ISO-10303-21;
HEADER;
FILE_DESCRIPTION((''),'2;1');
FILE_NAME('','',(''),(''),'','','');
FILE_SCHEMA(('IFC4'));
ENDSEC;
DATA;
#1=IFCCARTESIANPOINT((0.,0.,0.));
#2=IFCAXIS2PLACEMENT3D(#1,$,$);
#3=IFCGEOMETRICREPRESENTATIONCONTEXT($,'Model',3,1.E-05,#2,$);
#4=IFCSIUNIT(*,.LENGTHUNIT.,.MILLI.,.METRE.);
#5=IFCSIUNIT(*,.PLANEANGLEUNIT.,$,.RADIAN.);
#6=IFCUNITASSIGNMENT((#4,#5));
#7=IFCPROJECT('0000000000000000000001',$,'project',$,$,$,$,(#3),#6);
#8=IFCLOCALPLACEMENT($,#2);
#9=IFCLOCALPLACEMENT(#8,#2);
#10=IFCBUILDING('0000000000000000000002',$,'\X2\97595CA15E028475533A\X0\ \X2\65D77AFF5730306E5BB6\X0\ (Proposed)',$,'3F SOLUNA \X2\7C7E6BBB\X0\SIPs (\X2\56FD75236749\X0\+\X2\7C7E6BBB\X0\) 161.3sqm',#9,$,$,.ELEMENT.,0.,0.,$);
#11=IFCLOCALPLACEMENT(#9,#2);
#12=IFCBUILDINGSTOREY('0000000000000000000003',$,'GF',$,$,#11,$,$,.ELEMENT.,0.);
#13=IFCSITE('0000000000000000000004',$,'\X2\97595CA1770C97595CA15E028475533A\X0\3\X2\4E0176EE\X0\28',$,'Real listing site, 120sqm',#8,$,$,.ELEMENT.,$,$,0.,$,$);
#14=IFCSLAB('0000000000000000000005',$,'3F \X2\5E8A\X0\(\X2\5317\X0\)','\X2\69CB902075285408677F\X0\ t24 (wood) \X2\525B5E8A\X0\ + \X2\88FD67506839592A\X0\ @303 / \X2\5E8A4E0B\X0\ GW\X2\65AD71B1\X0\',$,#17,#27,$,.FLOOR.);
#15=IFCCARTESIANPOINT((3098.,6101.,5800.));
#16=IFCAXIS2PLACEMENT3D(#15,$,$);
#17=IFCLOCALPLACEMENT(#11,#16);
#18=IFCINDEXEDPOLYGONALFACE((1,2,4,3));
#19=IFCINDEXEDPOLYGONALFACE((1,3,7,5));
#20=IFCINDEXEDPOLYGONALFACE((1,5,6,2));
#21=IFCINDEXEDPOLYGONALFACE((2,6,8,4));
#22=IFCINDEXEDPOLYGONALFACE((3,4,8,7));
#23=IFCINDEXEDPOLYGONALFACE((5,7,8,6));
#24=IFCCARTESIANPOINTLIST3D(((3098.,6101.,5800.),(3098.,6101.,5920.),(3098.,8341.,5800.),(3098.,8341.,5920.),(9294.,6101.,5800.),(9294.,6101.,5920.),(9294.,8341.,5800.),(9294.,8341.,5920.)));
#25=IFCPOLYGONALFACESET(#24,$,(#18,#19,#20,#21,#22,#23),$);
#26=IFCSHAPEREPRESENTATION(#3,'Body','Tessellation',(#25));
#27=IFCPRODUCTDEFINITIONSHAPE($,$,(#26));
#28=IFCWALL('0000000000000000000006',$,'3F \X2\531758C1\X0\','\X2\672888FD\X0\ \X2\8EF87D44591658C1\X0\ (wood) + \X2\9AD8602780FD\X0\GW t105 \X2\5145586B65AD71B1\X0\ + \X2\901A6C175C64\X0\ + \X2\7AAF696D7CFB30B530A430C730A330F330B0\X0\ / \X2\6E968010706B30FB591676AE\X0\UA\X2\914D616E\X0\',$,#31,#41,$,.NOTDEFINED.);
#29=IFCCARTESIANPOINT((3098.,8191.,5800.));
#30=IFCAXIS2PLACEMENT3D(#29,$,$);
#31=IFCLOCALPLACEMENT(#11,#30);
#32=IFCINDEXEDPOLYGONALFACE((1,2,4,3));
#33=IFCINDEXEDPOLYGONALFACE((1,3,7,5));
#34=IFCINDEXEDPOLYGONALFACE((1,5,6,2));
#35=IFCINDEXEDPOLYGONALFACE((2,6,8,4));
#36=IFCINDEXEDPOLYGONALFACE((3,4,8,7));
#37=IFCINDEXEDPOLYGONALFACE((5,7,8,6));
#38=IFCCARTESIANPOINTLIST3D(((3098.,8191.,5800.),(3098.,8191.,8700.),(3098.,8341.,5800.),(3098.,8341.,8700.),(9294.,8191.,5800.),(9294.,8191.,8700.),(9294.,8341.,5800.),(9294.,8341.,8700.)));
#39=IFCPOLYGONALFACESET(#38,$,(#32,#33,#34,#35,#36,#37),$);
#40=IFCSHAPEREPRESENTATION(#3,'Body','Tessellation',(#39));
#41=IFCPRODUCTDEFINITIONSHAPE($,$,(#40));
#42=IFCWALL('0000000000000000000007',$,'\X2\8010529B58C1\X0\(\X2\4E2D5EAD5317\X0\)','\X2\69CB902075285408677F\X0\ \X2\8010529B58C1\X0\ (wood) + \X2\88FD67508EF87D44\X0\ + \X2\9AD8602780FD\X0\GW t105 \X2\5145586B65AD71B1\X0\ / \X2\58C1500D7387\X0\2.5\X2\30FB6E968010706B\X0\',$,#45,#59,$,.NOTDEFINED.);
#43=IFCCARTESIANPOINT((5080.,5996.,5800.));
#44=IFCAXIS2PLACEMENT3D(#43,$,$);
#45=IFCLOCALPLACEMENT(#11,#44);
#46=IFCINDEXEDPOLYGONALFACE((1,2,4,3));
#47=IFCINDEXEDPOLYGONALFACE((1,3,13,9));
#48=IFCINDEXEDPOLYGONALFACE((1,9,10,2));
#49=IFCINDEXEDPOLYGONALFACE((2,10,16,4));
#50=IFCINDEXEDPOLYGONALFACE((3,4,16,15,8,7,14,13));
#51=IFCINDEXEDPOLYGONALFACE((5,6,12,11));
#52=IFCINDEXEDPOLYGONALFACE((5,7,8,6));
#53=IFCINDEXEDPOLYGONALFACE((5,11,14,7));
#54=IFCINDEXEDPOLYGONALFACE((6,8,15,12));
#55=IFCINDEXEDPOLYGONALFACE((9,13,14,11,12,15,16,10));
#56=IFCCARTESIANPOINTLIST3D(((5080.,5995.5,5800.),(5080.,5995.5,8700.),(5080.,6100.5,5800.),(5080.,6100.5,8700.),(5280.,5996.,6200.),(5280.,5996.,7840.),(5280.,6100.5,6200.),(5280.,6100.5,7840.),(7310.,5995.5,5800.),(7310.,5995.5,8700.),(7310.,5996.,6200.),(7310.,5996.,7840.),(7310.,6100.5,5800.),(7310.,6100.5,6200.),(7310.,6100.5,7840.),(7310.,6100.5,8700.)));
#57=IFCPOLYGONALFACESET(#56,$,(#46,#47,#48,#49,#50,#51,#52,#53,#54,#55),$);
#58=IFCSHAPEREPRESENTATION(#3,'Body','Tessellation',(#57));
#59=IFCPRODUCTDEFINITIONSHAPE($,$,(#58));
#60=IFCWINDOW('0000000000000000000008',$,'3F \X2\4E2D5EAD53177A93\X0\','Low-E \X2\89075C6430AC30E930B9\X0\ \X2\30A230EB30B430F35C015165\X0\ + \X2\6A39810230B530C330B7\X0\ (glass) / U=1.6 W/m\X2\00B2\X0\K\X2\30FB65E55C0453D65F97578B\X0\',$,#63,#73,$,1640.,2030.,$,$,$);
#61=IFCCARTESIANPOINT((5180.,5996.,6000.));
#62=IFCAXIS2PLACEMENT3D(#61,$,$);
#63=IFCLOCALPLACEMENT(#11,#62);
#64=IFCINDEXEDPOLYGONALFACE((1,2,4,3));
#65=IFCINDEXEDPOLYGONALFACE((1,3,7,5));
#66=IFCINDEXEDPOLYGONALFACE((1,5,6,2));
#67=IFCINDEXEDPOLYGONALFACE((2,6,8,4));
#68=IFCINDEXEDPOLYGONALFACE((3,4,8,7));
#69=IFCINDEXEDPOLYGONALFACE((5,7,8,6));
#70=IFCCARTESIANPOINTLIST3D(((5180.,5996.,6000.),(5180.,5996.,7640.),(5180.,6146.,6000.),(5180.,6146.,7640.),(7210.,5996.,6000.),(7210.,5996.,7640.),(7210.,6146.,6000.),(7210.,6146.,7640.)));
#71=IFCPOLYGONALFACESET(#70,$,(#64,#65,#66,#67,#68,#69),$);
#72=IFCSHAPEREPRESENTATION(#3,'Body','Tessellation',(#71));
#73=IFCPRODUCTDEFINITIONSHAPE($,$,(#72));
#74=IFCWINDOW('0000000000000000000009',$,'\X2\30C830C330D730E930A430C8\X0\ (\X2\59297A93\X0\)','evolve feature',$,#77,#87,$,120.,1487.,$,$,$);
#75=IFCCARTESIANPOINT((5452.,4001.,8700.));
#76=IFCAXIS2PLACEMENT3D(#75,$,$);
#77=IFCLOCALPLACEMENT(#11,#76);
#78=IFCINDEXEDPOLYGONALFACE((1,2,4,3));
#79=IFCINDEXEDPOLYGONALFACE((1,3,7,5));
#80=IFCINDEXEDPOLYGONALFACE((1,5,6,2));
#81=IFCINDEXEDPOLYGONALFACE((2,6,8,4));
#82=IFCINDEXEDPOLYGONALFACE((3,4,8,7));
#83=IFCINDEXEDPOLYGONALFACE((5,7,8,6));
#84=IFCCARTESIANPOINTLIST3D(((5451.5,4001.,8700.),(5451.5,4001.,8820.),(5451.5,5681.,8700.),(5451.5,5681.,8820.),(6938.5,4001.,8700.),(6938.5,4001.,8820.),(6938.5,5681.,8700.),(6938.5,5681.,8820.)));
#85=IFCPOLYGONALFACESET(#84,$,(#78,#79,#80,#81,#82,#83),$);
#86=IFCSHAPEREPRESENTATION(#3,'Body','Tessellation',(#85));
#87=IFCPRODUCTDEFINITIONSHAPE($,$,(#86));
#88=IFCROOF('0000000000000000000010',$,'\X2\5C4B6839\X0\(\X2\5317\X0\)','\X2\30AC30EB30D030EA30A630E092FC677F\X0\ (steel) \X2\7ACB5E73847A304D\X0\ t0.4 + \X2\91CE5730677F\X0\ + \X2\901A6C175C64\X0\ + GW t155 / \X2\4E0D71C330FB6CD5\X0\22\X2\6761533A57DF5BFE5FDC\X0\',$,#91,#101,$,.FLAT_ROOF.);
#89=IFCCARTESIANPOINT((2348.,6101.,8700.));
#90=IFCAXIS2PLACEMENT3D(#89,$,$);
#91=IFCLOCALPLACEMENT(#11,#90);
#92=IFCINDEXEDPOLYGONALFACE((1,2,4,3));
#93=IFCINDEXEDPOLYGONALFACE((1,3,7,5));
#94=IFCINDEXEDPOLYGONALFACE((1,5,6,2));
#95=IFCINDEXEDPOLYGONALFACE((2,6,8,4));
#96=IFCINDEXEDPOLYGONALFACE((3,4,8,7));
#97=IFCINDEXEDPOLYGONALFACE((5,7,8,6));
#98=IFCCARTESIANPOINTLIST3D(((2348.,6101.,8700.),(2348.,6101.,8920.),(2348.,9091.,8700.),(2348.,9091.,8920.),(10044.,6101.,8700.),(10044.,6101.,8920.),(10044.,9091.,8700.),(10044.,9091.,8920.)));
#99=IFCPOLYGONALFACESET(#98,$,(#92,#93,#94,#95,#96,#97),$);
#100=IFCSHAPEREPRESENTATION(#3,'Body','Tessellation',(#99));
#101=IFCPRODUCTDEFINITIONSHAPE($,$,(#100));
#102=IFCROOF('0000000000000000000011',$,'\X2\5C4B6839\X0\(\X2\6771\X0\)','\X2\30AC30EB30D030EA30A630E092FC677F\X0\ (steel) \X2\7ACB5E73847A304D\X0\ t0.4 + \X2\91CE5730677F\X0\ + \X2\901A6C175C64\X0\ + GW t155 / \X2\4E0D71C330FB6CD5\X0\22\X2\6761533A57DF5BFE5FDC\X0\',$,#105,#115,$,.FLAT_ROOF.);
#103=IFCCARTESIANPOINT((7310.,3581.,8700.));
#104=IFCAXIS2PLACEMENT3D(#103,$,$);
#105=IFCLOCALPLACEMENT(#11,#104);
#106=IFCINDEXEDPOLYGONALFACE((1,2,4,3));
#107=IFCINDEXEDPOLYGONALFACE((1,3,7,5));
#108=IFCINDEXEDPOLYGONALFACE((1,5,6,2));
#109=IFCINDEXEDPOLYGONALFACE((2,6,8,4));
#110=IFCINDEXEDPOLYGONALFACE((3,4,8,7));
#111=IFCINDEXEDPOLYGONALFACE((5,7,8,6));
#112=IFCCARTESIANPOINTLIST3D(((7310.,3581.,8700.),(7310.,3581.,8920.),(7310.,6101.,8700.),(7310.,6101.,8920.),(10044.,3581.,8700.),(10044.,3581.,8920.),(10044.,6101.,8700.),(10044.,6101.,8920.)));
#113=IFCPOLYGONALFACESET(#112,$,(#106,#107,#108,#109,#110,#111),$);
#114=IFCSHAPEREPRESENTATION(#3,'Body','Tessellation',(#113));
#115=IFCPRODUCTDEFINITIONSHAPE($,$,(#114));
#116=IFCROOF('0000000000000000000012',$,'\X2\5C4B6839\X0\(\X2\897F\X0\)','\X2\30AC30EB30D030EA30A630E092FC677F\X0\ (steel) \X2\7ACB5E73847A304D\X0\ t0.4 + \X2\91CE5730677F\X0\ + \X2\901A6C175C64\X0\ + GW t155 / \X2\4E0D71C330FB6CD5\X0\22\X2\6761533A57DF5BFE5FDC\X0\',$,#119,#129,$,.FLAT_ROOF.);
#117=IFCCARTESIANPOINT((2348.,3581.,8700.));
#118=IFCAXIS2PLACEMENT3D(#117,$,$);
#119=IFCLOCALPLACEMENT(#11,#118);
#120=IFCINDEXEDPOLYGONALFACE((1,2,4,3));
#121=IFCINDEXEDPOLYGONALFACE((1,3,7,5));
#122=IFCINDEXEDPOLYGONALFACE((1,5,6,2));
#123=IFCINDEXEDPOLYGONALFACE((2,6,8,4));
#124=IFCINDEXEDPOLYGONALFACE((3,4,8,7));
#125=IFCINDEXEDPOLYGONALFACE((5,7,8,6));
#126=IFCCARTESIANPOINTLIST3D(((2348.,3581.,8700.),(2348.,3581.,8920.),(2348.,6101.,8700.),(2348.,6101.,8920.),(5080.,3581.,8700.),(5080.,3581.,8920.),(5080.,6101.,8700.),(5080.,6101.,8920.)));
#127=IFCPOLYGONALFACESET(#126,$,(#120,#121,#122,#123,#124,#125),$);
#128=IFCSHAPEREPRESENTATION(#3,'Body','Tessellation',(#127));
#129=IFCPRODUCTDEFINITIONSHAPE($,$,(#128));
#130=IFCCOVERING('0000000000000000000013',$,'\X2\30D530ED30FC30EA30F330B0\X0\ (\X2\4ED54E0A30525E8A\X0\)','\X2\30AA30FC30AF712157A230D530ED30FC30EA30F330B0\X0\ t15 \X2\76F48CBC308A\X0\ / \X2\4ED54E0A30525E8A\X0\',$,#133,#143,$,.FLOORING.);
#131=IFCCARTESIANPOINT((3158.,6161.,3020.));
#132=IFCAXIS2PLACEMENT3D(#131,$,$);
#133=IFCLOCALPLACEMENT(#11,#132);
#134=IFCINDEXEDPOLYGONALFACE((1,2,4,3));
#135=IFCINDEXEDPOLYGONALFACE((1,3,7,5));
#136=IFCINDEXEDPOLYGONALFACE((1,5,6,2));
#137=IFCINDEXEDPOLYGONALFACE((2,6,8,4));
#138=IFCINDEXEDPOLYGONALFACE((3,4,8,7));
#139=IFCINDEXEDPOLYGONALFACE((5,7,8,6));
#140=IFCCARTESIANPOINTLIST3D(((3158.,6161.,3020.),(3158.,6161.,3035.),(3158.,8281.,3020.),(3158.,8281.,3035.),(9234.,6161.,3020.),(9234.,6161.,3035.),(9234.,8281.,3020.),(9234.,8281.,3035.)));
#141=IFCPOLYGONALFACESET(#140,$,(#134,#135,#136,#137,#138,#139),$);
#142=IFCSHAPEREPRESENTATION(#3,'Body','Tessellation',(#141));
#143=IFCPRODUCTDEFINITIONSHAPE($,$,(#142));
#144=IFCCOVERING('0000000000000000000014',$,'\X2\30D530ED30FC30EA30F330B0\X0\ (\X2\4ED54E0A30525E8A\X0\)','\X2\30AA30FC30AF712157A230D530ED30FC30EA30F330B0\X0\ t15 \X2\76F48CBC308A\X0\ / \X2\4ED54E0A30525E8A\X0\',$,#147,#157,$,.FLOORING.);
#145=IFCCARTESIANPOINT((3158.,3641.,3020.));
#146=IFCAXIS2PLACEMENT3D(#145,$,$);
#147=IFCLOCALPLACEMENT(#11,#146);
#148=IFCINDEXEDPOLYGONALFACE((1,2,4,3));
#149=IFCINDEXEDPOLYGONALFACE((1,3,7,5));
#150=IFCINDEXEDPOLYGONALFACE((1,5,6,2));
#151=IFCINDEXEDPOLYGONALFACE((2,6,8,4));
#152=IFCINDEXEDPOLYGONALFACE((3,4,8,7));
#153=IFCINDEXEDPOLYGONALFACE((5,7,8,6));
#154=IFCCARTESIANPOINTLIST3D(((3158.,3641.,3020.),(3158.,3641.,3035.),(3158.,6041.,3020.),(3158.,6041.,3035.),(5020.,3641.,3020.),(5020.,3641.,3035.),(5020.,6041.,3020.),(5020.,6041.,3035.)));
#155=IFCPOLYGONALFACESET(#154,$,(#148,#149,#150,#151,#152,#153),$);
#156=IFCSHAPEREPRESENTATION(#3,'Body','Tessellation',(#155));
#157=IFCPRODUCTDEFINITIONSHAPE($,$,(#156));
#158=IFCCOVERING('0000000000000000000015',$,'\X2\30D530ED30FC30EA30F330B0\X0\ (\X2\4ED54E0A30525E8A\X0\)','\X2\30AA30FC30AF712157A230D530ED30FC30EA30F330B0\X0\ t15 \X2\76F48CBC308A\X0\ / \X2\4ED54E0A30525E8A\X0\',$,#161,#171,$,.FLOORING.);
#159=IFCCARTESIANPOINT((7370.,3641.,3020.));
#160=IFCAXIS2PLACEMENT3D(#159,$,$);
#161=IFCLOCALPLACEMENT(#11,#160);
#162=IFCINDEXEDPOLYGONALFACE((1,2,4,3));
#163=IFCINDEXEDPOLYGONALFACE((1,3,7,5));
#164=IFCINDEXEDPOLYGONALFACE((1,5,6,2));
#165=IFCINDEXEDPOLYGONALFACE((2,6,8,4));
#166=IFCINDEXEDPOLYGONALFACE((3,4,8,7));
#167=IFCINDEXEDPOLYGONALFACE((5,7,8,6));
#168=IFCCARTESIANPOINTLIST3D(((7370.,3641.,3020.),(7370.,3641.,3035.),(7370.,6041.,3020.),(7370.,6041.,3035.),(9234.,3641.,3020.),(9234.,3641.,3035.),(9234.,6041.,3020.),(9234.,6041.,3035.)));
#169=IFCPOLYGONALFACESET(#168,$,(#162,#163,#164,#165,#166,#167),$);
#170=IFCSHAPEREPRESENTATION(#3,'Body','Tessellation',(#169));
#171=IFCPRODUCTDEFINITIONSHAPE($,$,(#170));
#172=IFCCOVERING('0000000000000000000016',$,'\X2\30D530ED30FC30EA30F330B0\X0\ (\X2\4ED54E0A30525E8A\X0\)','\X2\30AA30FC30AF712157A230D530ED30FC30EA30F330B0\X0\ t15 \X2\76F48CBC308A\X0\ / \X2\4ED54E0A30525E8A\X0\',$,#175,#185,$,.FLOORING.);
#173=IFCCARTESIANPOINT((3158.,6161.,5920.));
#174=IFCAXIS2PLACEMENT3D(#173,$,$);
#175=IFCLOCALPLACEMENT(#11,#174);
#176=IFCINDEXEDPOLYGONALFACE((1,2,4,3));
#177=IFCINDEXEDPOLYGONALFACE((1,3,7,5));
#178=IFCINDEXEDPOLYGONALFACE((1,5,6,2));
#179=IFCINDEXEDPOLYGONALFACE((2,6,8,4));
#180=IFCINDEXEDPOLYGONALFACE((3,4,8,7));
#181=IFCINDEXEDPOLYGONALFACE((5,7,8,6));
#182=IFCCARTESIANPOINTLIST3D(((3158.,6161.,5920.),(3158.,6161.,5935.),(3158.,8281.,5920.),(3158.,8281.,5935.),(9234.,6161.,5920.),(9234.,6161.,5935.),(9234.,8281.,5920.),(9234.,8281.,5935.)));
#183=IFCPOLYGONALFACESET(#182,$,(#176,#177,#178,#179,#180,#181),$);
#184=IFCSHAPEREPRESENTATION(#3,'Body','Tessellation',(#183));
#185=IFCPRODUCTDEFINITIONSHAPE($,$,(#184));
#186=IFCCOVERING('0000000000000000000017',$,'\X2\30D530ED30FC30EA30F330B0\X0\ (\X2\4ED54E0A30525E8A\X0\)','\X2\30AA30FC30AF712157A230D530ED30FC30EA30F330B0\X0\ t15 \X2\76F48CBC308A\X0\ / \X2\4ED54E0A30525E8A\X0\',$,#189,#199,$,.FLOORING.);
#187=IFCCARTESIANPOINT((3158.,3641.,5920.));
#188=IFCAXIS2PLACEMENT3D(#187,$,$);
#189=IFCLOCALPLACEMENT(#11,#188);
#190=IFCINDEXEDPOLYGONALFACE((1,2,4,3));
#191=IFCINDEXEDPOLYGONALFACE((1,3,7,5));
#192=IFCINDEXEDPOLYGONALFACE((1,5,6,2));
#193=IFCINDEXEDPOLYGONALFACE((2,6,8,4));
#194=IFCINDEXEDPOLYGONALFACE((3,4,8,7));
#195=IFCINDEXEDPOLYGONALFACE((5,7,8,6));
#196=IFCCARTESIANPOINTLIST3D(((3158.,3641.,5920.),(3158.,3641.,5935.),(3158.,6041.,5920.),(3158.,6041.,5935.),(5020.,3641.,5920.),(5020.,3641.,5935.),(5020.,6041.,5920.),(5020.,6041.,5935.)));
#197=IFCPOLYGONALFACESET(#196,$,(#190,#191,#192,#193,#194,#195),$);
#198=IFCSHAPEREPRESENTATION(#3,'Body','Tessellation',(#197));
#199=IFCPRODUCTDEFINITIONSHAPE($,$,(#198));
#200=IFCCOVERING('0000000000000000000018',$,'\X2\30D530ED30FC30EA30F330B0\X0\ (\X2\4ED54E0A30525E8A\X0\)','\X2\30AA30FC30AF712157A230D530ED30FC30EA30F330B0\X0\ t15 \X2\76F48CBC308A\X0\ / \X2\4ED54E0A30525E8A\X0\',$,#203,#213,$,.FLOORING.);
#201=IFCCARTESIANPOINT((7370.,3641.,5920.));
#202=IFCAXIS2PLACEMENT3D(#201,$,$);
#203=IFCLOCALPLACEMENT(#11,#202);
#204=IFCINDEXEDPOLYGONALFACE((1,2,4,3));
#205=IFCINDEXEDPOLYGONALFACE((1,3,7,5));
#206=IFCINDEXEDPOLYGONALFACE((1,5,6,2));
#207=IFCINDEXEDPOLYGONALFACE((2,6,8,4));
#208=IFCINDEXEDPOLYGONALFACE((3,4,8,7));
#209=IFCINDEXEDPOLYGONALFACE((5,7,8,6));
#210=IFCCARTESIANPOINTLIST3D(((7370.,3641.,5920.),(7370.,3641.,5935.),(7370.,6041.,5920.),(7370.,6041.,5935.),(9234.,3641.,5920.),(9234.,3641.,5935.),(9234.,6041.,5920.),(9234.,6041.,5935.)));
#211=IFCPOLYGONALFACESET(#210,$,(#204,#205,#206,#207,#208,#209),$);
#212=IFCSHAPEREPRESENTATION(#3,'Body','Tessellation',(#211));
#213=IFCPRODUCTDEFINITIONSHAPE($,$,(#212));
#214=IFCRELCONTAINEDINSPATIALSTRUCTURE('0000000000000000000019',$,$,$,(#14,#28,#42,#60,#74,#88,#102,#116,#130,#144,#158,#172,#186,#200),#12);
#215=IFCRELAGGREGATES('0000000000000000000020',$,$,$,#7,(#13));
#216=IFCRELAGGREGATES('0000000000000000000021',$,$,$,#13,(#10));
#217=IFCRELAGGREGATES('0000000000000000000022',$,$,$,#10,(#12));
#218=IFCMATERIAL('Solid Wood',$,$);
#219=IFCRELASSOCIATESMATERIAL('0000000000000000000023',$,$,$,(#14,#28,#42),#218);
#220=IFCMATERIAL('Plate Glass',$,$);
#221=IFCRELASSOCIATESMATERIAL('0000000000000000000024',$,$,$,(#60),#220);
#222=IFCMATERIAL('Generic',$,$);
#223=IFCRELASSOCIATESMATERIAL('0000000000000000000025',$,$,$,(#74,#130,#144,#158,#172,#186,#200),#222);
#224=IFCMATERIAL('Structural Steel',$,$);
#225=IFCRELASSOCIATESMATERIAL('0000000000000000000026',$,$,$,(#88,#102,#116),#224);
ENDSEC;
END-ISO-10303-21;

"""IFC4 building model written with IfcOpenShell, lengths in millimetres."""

from ifc_helpers import new_model, si_unit, frame, frame_2d, origin, place, context, project, spatial, rectangle, extrude, material, element, fill, save


model = new_model("IFC4")

# Units and contexts
model_context = context("Model", 3, precision=1e-05, world=origin())
ifc_project = project(units=[si_unit("LENGTHUNIT", "METRE", prefix="MILLI"), si_unit("PLANEANGLEUNIT", "RADIAN")], contexts=[model_context])

# Site, building, storey
site_placement = place(None, origin())
site = spatial("IfcSite", under=ifc_project, at=site_placement, Name="静岡県静岡市葵区3丁目28", ObjectType="Real listing site, 120sqm", CompositionType="ELEMENT", RefElevation=0.0)
building_placement = place(site_placement, origin())
building = spatial("IfcBuilding", under=site, at=building_placement, Name="静岡市葵区 旗竿地の家 (Proposed)", ObjectType="3F SOLUNA 籾殻SIPs (国産杉+籾殻) 161.3sqm", CompositionType="ELEMENT", ElevationOfRefHeight=0.0, ElevationOfTerrain=0.0)
storey_placement = place(building_placement, origin())
storey = spatial("IfcBuildingStorey", under=building, at=storey_placement, Name="GF", CompositionType="ELEMENT", Elevation=0.0)

# Slab
ifc_material_1 = material(Name="Solid Wood")
slab_placement = place(storey_placement, frame((3098.0, 6101.0, 5800.0)))
element("IfcSlab", 1, at=slab_placement, inside=storey, material=ifc_material_1, Name="3F 床(北)", Description="構造用合板 t24 (wood) 剛床 + 製材根太 @303 / 床下 GW断熱", PredefinedType="FLOOR", context=model_context, shape_type="SweptSolid", body=[
    extrude(rectangle(XDim=6196.0, YDim=2240.0, at=frame_2d((3098.0, 1120.0))), frame((3098.0, 6101.0, 5800.0)), (0.0, 0.0, 1.0), 120.0),
])

# Wall
wall_1_placement = place(storey_placement, frame((3098.0, 8191.0, 5800.0)))
element("IfcWall", 2, at=wall_1_placement, inside=storey, material=ifc_material_1, Name="3F 北壁", Description="木製 軸組外壁 (wood) + 高性能GW t105 充填断熱 + 通気層 + 窯業系サイディング / 準耐火・外皮UA配慮", PredefinedType="NOTDEFINED", context=model_context, shape_type="SweptSolid", body=[
    extrude(rectangle(XDim=6196.0, YDim=150.0, at=frame_2d((3098.0, 75.0))), frame((3098.0, 8191.0, 5800.0)), (0.0, 0.0, 1.0), 2900.0),
])

# Wall, opening, window
wall_2_placement = place(storey_placement, frame((5080.0, 5996.0, 5800.0)))
wall_2 = element("IfcWall", 3, at=wall_2_placement, inside=storey, material=ifc_material_1, Name="耐力壁(中庭北)", Description="構造用合板 耐力壁 (wood) + 製材軸組 + 高性能GW t105 充填断熱 / 壁倍率2.5・準耐火", PredefinedType="NOTDEFINED", context=model_context, shape_type="SweptSolid", body=[
    extrude(rectangle(XDim=2230.0, YDim=105.0, at=frame_2d((1115.0, 52.0))), frame((5080.0, 5996.0, 5800.0)), (0.0, 0.0, 1.0), 2900.0),
])
opening_placement = place(storey_placement, frame((5180.0, 5996.0, 6000.0)))
opening = element("IfcOpeningElement", 4, at=opening_placement, cuts=wall_2, PredefinedType="NOTDEFINED", context=model_context, shape_type="SweptSolid", body=[
    extrude(rectangle(XDim=2030.0, YDim=150.0, at=frame_2d((1015.0, 75.0))), frame((5180.0, 5996.0, 6000.0)), (0.0, 0.0, 1.0), 1640.0),
])
ifc_material_2 = material(Name="Plate Glass")
window_1_placement = place(storey_placement, frame((5180.0, 5996.0, 6000.0)))
window_1 = element("IfcWindow", 5, at=window_1_placement, inside=storey, material=ifc_material_2, Name="3F 中庭北窓", Description="Low-E 複層ガラス アルゴン封入 + 樹脂サッシ (glass) / U=1.6 W/m²K・日射取得型", OverallHeight=1640.0, OverallWidth=2030.0, context=model_context, shape_type="SweptSolid", body=[
    extrude(rectangle(XDim=2030.0, YDim=150.0, at=frame_2d((1015.0, 75.0))), frame((5180.0, 5996.0, 6000.0)), (0.0, 0.0, 1.0), 1640.0),
])
fill(opening, window_1)

# Window
ifc_material_3 = material(Name="Generic")
window_2_placement = place(storey_placement, frame((5452.0, 4001.0, 8700.0)))
element("IfcWindow", 6, at=window_2_placement, inside=storey, material=ifc_material_3, Name="トップライト (天窓)", Description="evolve feature", OverallHeight=120.0, OverallWidth=1487.0, context=model_context, shape_type="SweptSolid", body=[
    extrude(rectangle(XDim=1487.0, YDim=1680.0, at=frame_2d((743.0, 840.0))), frame((5452.0, 4001.0, 8700.0)), (0.0, 0.0, 1.0), 120.0),
])

# Roofs
ifc_material_4 = material(Name="Structural Steel")
roof_1_placement = place(storey_placement, frame((2348.0, 6101.0, 8700.0)))
element("IfcRoof", 7, at=roof_1_placement, inside=storey, material=ifc_material_4, Name="屋根(北)", Description="ガルバリウム鋼板 (steel) 立平葺き t0.4 + 野地板 + 通気層 + GW t155 / 不燃・法22条区域対応", PredefinedType="FLAT_ROOF", context=model_context, shape_type="SweptSolid", body=[
    extrude(rectangle(XDim=7696.0, YDim=2990.0, at=frame_2d((3848.0, 1495.0))), frame((2348.0, 6101.0, 8700.0)), (0.0, 0.0, 1.0), 220.0),
])
roof_2_placement = place(storey_placement, frame((7310.0, 3581.0, 8700.0)))
element("IfcRoof", 8, at=roof_2_placement, inside=storey, material=ifc_material_4, Name="屋根(東)", Description="ガルバリウム鋼板 (steel) 立平葺き t0.4 + 野地板 + 通気層 + GW t155 / 不燃・法22条区域対応", PredefinedType="FLAT_ROOF", context=model_context, shape_type="SweptSolid", body=[
    extrude(rectangle(XDim=2734.0, YDim=2520.0, at=frame_2d((1367.0, 1260.0))), frame((7310.0, 3581.0, 8700.0)), (0.0, 0.0, 1.0), 220.0),
])
roof_3_placement = place(storey_placement, frame((2348.0, 3581.0, 8700.0)))
element("IfcRoof", 9, at=roof_3_placement, inside=storey, material=ifc_material_4, Name="屋根(西)", Description="ガルバリウム鋼板 (steel) 立平葺き t0.4 + 野地板 + 通気層 + GW t155 / 不燃・法22条区域対応", PredefinedType="FLAT_ROOF", context=model_context, shape_type="SweptSolid", body=[
    extrude(rectangle(XDim=2732.0, YDim=2520.0, at=frame_2d((1366.0, 1260.0))), frame((2348.0, 3581.0, 8700.0)), (0.0, 0.0, 1.0), 220.0),
])

# Coverings
covering_1_placement = place(storey_placement, frame((3158.0, 6161.0, 3020.0)))
element("IfcCovering", 10, at=covering_1_placement, inside=storey, material=ifc_material_3, Name="フローリング (仕上げ床)", Description="オーク無垢フローリング t15 直貼り / 仕上げ床", PredefinedType="FLOORING", context=model_context, shape_type="SweptSolid", body=[
    extrude(rectangle(XDim=6076.0, YDim=2120.0, at=frame_2d((3038.0, 1060.0))), frame((3158.0, 6161.0, 3020.0)), (0.0, 0.0, 1.0), 15.0),
])
covering_2_placement = place(storey_placement, frame((3158.0, 3641.0, 3020.0)))
element("IfcCovering", 11, at=covering_2_placement, inside=storey, material=ifc_material_3, Name="フローリング (仕上げ床)", Description="オーク無垢フローリング t15 直貼り / 仕上げ床", PredefinedType="FLOORING", context=model_context, shape_type="SweptSolid", body=[
    extrude(rectangle(XDim=1862.0, YDim=2400.0, at=frame_2d((931.0, 1200.0))), frame((3158.0, 3641.0, 3020.0)), (0.0, 0.0, 1.0), 15.0),
])
covering_3_placement = place(storey_placement, frame((7370.0, 3641.0, 3020.0)))
element("IfcCovering", 12, at=covering_3_placement, inside=storey, material=ifc_material_3, Name="フローリング (仕上げ床)", Description="オーク無垢フローリング t15 直貼り / 仕上げ床", PredefinedType="FLOORING", context=model_context, shape_type="SweptSolid", body=[
    extrude(rectangle(XDim=1864.0, YDim=2400.0, at=frame_2d((932.0, 1200.0))), frame((7370.0, 3641.0, 3020.0)), (0.0, 0.0, 1.0), 15.0),
])
covering_4_placement = place(storey_placement, frame((3158.0, 6161.0, 5920.0)))
element("IfcCovering", 13, at=covering_4_placement, inside=storey, material=ifc_material_3, Name="フローリング (仕上げ床)", Description="オーク無垢フローリング t15 直貼り / 仕上げ床", PredefinedType="FLOORING", context=model_context, shape_type="SweptSolid", body=[
    extrude(rectangle(XDim=6076.0, YDim=2120.0, at=frame_2d((3038.0, 1060.0))), frame((3158.0, 6161.0, 5920.0)), (0.0, 0.0, 1.0), 15.0),
])
covering_5_placement = place(storey_placement, frame((3158.0, 3641.0, 5920.0)))
element("IfcCovering", 14, at=covering_5_placement, inside=storey, material=ifc_material_3, Name="フローリング (仕上げ床)", Description="オーク無垢フローリング t15 直貼り / 仕上げ床", PredefinedType="FLOORING", context=model_context, shape_type="SweptSolid", body=[
    extrude(rectangle(XDim=1862.0, YDim=2400.0, at=frame_2d((931.0, 1200.0))), frame((3158.0, 3641.0, 5920.0)), (0.0, 0.0, 1.0), 15.0),
])
covering_6_placement = place(storey_placement, frame((7370.0, 3641.0, 5920.0)))
element("IfcCovering", 15, at=covering_6_placement, inside=storey, material=ifc_material_3, Name="フローリング (仕上げ床)", Description="オーク無垢フローリング t15 直貼り / 仕上げ床", PredefinedType="FLOORING", context=model_context, shape_type="SweptSolid", body=[
    extrude(rectangle(XDim=1864.0, YDim=2400.0, at=frame_2d((932.0, 1200.0))), frame((7370.0, 3641.0, 5920.0)), (0.0, 0.0, 1.0), 15.0),
])

save(model, "model.ifc")
